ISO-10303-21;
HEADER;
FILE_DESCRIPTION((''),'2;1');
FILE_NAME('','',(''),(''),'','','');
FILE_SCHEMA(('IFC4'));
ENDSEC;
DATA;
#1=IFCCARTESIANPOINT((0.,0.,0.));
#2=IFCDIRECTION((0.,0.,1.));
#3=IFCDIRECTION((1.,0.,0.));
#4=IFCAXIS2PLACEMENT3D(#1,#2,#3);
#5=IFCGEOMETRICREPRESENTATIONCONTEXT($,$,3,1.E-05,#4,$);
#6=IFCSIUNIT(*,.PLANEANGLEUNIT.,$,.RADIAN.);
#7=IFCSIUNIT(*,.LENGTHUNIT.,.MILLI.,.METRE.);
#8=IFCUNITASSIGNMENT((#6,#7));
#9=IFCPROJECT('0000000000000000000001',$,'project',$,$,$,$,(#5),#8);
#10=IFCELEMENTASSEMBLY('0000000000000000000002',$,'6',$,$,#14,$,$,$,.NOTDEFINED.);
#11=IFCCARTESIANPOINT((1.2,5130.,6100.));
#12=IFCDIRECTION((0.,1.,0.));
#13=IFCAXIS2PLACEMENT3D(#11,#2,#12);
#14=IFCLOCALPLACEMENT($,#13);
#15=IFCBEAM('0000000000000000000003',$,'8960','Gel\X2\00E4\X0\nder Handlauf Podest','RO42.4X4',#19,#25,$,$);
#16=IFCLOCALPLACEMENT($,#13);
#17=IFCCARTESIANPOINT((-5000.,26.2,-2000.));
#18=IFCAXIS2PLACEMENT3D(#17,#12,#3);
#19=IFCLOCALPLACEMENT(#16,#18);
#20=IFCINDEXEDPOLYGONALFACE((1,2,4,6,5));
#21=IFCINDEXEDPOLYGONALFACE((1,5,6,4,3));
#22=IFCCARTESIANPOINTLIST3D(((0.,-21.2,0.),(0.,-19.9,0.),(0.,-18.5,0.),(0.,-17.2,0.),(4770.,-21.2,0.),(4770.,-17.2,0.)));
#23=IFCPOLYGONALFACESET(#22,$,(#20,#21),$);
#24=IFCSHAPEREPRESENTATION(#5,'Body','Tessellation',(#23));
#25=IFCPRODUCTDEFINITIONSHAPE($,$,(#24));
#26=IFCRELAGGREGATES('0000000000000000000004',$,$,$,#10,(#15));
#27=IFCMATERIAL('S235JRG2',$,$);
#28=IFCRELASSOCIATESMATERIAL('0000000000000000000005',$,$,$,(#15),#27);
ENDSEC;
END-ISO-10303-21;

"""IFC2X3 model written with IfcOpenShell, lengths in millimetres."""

from ifc_helpers import new_model, si_unit, frame, origin_with_axes, place, context, project, polyline, outline, extrude, material, element, aggregate, save


model = new_model("IFC2X3")

# Units and contexts
context_of_model = context(None, 3, precision=1e-05, world=origin_with_axes())
ifc_project = project(units=[si_unit("PLANEANGLEUNIT", "RADIAN"), si_unit("LENGTHUNIT", "METRE", prefix="MILLI")], contexts=[context_of_model])

# Element assembly, beam
assembly_1_placement = place(None, frame((1.2, 5130.0, 6100.0), z_axis=(0.0, 0.0, 1.0), x_axis=(0.0, 1.0, 0.0)))
assembly_1 = element("IfcElementAssembly", 1, at=assembly_1_placement, Name="6", PredefinedType="NOTDEFINED")
ifc_material = material(Name="S235JRG2")
placement_1 = place(None, frame((1.2, 5130.0, 6100.0), z_axis=(0.0, 0.0, 1.0), x_axis=(0.0, 1.0, 0.0)))
beam_1_placement = place(placement_1, frame((-5000.0, 26.2, -2000.0), z_axis=(0.0, 1.0, 0.0), x_axis=(1.0, 0.0, 0.0)))
beam_1 = element("IfcBeam", 2, at=beam_1_placement, material=ifc_material, Name="8960", Description="Geländer Handlauf Podest", ObjectType="RO42.4X4", context=context_of_model, shape_type="SweptSolid", body=[
    extrude(outline(polyline([(-21.2, 0.0), (-21.2, 0.0), (-17.2, 0.0), (-17.2, 0.0), (-21.2, 0.0)])), frame((0.0, 0.0, 0.0), z_axis=(1.0, 0.0, 0.0), x_axis=(0.0, 1.0, 0.0)), (0.0, 0.0, 1.0), 4770.0),
])
aggregate(assembly_1, [beam_1])

save(model, "model.ifc")
